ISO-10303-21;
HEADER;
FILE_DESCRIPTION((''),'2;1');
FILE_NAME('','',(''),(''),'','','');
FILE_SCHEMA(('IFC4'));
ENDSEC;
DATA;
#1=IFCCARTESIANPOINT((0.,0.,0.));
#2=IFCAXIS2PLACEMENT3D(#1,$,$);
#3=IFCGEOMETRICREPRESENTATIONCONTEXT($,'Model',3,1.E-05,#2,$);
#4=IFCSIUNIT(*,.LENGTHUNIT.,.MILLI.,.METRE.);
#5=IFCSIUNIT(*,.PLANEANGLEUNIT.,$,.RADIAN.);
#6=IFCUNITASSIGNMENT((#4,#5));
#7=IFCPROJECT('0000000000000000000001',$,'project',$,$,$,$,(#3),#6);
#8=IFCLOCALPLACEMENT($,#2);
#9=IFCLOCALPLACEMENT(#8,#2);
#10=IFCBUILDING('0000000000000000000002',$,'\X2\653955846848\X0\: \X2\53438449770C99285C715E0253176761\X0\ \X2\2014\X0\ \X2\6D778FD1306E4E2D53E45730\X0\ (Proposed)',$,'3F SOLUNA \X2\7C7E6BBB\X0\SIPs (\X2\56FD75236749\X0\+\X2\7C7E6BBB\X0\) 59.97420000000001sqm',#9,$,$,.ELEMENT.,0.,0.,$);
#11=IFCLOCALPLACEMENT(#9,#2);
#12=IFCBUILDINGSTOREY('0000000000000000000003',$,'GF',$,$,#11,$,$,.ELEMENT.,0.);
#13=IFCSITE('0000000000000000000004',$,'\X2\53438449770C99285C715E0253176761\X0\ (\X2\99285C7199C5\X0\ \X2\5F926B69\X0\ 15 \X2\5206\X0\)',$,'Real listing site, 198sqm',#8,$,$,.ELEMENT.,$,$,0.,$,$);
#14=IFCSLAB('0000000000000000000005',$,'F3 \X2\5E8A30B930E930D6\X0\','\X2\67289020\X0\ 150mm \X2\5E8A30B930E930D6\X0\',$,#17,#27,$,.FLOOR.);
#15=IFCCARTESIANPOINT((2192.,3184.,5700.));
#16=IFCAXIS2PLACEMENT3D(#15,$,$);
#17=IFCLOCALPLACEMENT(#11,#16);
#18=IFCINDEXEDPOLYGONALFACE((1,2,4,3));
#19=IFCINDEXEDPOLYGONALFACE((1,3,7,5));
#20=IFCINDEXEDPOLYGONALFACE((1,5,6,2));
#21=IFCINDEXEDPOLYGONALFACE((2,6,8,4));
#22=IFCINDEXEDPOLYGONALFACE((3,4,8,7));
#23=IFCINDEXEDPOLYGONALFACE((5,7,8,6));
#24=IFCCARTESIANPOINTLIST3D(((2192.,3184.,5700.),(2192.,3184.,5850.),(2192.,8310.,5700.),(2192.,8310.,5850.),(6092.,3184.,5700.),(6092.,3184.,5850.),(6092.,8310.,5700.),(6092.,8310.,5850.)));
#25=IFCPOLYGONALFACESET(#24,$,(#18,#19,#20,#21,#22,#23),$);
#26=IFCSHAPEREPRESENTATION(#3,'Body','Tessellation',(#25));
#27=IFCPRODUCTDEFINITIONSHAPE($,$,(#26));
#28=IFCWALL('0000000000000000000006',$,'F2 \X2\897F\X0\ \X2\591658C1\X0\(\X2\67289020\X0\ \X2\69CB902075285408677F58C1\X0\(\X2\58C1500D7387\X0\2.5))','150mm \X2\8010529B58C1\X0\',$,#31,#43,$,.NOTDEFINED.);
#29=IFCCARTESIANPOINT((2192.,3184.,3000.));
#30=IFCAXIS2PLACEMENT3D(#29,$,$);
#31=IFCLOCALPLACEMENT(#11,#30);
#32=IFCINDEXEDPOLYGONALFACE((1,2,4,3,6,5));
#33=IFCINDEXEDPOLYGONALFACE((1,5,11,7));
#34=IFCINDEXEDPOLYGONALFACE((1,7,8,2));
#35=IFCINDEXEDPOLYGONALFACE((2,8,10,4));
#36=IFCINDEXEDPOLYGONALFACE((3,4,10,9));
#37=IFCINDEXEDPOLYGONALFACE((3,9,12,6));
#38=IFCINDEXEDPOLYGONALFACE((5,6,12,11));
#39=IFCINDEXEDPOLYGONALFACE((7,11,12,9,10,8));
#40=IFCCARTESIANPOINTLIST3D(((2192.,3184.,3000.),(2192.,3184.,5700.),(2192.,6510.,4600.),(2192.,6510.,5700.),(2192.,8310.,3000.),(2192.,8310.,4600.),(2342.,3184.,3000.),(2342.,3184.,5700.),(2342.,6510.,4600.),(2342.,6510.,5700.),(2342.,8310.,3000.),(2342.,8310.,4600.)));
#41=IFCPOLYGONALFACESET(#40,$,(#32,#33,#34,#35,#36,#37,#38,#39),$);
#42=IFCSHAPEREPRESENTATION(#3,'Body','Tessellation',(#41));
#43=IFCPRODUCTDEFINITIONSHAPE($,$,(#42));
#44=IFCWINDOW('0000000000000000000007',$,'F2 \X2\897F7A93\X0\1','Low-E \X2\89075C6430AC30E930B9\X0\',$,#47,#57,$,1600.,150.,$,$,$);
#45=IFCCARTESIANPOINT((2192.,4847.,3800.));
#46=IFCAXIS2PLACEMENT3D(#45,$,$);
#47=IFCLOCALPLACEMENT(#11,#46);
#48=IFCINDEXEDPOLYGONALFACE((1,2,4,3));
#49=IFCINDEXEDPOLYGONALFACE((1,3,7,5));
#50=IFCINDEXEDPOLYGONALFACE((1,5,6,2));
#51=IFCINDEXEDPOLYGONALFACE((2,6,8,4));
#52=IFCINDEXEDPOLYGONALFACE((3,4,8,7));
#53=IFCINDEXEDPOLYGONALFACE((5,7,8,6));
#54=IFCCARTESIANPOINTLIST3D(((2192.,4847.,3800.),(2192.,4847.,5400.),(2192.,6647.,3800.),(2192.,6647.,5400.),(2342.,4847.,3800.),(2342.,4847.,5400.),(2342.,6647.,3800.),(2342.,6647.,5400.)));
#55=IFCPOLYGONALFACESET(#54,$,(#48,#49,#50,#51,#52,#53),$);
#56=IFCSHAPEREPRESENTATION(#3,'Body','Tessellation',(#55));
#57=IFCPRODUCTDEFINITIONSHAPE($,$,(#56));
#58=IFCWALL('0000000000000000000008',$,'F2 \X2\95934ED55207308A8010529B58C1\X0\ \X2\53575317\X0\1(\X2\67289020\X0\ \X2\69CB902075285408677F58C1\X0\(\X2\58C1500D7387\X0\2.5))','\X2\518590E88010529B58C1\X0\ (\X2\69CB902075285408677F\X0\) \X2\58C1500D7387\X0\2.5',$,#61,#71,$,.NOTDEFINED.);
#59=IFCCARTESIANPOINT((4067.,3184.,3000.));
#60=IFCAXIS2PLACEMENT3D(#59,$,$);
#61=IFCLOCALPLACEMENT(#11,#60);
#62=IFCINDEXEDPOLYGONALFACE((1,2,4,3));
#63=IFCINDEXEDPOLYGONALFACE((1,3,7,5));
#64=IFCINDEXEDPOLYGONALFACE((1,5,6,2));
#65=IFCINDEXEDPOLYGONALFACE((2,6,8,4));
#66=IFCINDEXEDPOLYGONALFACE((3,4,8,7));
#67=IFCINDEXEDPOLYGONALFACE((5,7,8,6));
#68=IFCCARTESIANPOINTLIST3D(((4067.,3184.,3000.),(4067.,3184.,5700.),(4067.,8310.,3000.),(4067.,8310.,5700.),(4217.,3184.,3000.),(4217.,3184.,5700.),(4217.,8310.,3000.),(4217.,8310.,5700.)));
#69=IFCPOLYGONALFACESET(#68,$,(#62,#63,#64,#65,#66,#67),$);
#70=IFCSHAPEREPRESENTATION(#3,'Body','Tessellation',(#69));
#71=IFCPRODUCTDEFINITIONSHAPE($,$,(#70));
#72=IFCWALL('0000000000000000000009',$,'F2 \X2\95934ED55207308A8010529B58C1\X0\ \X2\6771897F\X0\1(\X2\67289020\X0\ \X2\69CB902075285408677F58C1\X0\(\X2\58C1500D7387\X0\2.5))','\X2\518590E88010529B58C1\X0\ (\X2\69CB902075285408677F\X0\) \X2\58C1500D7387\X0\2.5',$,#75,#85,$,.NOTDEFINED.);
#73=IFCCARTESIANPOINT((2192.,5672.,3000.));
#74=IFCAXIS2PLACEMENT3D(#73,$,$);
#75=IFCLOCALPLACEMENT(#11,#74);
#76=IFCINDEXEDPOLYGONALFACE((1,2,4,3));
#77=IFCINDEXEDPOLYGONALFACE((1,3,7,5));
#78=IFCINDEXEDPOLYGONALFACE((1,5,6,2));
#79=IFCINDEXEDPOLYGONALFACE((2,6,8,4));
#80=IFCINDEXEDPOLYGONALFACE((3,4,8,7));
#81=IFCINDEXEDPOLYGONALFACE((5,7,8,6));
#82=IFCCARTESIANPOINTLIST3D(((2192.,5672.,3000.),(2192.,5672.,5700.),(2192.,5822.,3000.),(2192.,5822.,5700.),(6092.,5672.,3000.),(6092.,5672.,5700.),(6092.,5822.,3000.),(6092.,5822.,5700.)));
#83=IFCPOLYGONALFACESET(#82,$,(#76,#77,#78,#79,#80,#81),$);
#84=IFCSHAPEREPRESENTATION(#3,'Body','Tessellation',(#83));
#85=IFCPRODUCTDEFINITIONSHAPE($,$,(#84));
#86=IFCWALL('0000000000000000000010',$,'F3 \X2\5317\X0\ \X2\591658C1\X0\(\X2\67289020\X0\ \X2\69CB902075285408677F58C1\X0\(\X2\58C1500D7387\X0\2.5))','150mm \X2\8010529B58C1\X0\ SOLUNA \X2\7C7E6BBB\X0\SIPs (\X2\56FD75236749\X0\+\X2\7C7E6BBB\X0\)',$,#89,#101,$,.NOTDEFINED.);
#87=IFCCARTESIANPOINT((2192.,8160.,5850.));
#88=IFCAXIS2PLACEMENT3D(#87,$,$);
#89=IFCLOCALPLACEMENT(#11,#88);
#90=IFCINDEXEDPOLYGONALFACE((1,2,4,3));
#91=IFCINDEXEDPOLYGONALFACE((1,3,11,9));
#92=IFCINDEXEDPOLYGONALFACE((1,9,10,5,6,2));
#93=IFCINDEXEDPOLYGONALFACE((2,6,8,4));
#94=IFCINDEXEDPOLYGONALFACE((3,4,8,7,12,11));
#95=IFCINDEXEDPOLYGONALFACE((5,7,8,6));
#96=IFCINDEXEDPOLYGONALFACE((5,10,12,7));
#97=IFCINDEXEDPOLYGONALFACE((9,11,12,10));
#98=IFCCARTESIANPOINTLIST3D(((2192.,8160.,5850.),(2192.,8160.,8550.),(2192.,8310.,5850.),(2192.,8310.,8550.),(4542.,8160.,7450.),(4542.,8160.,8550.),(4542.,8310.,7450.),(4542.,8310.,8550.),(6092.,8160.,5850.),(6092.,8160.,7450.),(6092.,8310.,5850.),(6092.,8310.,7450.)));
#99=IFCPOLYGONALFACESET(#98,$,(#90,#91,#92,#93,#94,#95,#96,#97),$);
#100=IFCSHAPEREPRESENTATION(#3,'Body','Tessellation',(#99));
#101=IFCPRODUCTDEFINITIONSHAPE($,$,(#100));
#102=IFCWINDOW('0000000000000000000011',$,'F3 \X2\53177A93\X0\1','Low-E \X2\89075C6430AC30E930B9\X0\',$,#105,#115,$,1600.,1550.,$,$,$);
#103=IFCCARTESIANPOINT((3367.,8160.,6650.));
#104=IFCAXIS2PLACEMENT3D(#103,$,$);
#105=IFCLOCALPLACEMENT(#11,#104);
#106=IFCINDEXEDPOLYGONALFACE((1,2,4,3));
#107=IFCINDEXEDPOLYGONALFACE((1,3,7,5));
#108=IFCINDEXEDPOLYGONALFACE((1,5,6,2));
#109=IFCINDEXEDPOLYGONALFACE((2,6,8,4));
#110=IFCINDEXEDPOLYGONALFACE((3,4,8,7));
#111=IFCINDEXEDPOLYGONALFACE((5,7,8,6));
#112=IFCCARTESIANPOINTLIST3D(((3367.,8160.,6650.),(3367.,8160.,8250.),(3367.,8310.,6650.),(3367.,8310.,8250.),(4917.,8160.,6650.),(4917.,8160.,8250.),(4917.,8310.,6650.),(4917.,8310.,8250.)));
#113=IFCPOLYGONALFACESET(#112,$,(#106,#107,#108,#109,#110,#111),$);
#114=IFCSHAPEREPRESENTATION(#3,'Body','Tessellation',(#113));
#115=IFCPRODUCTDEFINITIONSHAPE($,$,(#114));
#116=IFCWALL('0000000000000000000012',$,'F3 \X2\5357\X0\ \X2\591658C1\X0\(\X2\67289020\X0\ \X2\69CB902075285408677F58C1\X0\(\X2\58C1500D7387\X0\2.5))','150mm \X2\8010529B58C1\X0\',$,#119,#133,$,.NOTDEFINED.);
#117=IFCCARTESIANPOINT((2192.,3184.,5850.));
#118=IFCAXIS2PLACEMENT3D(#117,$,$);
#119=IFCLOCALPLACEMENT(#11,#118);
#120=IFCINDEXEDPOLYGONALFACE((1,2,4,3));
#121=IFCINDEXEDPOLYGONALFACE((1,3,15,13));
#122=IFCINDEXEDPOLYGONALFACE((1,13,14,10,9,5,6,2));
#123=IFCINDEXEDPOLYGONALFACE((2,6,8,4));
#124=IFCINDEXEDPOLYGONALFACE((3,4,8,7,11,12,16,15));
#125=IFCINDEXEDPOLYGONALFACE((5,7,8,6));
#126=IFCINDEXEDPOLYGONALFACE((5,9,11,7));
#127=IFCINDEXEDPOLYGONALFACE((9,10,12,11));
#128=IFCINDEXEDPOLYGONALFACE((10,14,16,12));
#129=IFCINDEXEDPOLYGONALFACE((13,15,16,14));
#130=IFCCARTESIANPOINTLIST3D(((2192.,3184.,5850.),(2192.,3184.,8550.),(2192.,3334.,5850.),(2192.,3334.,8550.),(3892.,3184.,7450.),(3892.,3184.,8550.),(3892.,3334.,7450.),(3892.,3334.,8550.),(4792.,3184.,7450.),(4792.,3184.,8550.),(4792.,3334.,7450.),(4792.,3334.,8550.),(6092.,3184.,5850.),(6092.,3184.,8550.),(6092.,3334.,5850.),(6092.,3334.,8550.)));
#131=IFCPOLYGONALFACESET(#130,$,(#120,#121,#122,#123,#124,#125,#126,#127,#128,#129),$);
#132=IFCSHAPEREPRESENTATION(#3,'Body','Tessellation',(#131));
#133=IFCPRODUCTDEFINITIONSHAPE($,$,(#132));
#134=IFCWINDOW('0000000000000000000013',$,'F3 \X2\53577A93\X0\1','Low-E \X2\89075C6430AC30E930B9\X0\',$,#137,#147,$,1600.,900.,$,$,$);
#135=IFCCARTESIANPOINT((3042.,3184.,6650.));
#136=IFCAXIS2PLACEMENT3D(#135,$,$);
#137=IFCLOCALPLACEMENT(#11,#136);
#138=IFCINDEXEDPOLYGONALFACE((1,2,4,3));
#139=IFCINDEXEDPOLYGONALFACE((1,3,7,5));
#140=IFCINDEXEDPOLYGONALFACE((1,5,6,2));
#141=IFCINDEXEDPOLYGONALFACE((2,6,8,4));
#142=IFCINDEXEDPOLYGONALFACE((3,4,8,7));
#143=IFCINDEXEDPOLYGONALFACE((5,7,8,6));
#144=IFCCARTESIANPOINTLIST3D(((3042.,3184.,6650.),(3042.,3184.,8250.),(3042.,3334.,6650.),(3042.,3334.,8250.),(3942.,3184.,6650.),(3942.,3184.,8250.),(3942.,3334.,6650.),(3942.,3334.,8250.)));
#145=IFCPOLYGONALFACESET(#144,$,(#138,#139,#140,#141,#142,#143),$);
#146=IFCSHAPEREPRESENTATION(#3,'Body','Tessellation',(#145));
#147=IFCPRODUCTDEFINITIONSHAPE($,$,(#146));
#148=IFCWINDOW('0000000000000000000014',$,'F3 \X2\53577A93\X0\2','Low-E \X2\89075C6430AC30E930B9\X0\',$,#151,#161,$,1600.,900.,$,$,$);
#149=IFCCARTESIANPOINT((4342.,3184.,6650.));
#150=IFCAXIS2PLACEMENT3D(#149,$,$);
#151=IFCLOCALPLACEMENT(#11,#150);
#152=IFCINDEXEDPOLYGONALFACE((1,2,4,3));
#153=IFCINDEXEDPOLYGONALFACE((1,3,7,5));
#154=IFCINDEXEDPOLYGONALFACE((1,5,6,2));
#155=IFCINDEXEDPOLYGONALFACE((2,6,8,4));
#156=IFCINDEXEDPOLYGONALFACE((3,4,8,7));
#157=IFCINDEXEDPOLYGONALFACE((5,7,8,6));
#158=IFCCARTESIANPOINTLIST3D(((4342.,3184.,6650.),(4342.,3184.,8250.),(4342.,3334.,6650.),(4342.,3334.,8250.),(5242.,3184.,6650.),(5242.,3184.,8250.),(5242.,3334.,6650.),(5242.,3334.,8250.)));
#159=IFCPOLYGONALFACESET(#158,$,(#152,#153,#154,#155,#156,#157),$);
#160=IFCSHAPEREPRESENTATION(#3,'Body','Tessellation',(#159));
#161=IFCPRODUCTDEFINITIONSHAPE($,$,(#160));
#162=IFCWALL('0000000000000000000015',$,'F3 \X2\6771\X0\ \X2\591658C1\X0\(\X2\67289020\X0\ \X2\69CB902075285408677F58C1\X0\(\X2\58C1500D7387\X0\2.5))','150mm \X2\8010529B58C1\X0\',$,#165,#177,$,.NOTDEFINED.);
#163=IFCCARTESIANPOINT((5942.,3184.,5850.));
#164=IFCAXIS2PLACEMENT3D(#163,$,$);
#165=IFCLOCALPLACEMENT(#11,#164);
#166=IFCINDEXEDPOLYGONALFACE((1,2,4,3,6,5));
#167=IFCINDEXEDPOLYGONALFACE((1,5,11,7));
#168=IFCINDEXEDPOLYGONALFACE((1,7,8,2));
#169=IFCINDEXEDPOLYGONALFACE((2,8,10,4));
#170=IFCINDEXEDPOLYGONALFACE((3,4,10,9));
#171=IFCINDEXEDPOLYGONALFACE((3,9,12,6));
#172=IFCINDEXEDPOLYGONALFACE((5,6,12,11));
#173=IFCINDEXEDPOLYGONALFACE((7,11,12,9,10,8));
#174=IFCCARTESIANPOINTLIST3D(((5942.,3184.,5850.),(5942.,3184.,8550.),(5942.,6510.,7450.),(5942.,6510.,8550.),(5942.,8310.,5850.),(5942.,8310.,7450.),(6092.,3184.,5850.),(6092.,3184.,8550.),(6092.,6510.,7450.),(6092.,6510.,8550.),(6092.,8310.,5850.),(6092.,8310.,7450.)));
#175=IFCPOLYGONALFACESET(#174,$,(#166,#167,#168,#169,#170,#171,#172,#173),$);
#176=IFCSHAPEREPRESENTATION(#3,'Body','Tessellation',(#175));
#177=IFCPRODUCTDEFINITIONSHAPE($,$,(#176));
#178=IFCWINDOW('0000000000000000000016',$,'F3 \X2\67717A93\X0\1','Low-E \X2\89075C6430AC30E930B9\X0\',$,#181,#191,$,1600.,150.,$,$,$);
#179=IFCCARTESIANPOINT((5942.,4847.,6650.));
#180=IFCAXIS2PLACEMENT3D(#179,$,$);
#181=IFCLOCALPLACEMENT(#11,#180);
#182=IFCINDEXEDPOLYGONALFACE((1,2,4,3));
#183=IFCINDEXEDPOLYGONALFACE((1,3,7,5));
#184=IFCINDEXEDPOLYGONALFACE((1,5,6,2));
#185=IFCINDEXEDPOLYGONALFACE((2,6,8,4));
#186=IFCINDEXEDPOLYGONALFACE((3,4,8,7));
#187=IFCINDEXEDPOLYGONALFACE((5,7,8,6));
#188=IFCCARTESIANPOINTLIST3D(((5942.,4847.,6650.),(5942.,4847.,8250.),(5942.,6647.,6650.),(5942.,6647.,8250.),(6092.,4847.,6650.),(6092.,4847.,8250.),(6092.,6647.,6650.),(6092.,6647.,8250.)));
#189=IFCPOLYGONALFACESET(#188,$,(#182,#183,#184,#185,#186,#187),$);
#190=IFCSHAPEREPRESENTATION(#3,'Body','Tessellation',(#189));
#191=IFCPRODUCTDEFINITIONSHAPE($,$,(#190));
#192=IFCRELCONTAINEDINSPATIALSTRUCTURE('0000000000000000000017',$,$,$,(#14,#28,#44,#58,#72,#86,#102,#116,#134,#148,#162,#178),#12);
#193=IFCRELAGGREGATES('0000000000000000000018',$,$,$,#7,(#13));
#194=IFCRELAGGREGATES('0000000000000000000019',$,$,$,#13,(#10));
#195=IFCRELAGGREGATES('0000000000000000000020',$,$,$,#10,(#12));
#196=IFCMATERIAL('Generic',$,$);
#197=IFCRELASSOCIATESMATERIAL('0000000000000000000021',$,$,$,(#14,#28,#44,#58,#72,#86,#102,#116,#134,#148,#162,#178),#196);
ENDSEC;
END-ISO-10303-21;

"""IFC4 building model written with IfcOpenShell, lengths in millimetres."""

from ifc_helpers import new_model, si_unit, frame, frame_2d, origin, place, context, project, spatial, rectangle, extrude, material, element, fill, save


model = new_model("IFC4")

# Units and contexts
model_context = context("Model", 3, precision=1e-05, world=origin())
ifc_project = project(units=[si_unit("LENGTHUNIT", "METRE", prefix="MILLI"), si_unit("PLANEANGLEUNIT", "RADIAN")], contexts=[model_context])

# Site, building, storey
site_placement = place(None, origin())
site = spatial("IfcSite", under=ifc_project, at=site_placement, Name="千葉県館山市北条 (館山駅 徒歩 15 分)", ObjectType="Real listing site, 198sqm", CompositionType="ELEMENT", RefElevation=0.0)
building_placement = place(site_placement, origin())
building = spatial("IfcBuilding", under=site, at=building_placement, Name="改善案: 千葉県館山市北条 — 海近の中古地 (Proposed)", ObjectType="3F SOLUNA 籾殻SIPs (国産杉+籾殻) 59.97420000000001sqm", CompositionType="ELEMENT", ElevationOfRefHeight=0.0, ElevationOfTerrain=0.0)
storey_placement = place(building_placement, origin())
storey = spatial("IfcBuildingStorey", under=building, at=storey_placement, Name="GF", CompositionType="ELEMENT", Elevation=0.0)

# Slab
ifc_material_1 = material(Name="Generic")
slab_placement = place(storey_placement, frame((2192.0, 3184.0, 5700.0)))
element("IfcSlab", 1, at=slab_placement, inside=storey, material=ifc_material_1, Name="F3 床スラブ", Description="木造 150mm 床スラブ", PredefinedType="FLOOR", context=model_context, shape_type="SweptSolid", body=[
    extrude(rectangle(XDim=3900.0, YDim=5126.0, at=frame_2d((1950.0, 2563.0))), frame((2192.0, 3184.0, 5700.0)), (0.0, 0.0, 1.0), 150.0),
])

# Wall, opening, window
wall_1_placement = place(storey_placement, frame((2192.0, 3184.0, 3000.0)))
wall_1 = element("IfcWall", 2, at=wall_1_placement, inside=storey, material=ifc_material_1, Name="F2 西 外壁(木造 構造用合板壁(壁倍率2.5))", Description="150mm 耐力壁", PredefinedType="NOTDEFINED", context=model_context, shape_type="SweptSolid", body=[
    extrude(rectangle(XDim=150.0, YDim=5126.0, at=frame_2d((75.0, 2563.0))), frame((2192.0, 3184.0, 3000.0)), (0.0, 0.0, 1.0), 2700.0),
])
opening_1_placement = place(storey_placement, frame((2192.0, 4847.0, 3800.0)))
opening_1 = element("IfcOpeningElement", 3, at=opening_1_placement, cuts=wall_1, PredefinedType="NOTDEFINED", context=model_context, shape_type="SweptSolid", body=[
    extrude(rectangle(XDim=150.0, YDim=1800.0, at=frame_2d((75.0, 900.0))), frame((2192.0, 4847.0, 3800.0)), (0.0, 0.0, 1.0), 1600.0),
])
window_1_placement = place(storey_placement, frame((2192.0, 4847.0, 3800.0)))
window_1 = element("IfcWindow", 4, at=window_1_placement, inside=storey, material=ifc_material_1, Name="F2 西窓1", Description="Low-E 複層ガラス", OverallHeight=1600.0, OverallWidth=150.0, context=model_context, shape_type="SweptSolid", body=[
    extrude(rectangle(XDim=150.0, YDim=1800.0, at=frame_2d((75.0, 900.0))), frame((2192.0, 4847.0, 3800.0)), (0.0, 0.0, 1.0), 1600.0),
])
fill(opening_1, window_1)

# Walls
wall_2_placement = place(storey_placement, frame((4067.0, 3184.0, 3000.0)))
element("IfcWall", 5, at=wall_2_placement, inside=storey, material=ifc_material_1, Name="F2 間仕切り耐力壁 南北1(木造 構造用合板壁(壁倍率2.5))", Description="内部耐力壁 (構造用合板) 壁倍率2.5", PredefinedType="NOTDEFINED", context=model_context, shape_type="SweptSolid", body=[
    extrude(rectangle(XDim=150.0, YDim=5126.0, at=frame_2d((75.0, 2563.0))), frame((4067.0, 3184.0, 3000.0)), (0.0, 0.0, 1.0), 2700.0),
])
wall_3_placement = place(storey_placement, frame((2192.0, 5672.0, 3000.0)))
element("IfcWall", 6, at=wall_3_placement, inside=storey, material=ifc_material_1, Name="F2 間仕切り耐力壁 東西1(木造 構造用合板壁(壁倍率2.5))", Description="内部耐力壁 (構造用合板) 壁倍率2.5", PredefinedType="NOTDEFINED", context=model_context, shape_type="SweptSolid", body=[
    extrude(rectangle(XDim=3900.0, YDim=150.0, at=frame_2d((1950.0, 75.0))), frame((2192.0, 5672.0, 3000.0)), (0.0, 0.0, 1.0), 2700.0),
])

# Wall, opening, window
wall_4_placement = place(storey_placement, frame((2192.0, 8160.0, 5850.0)))
wall_4 = element("IfcWall", 7, at=wall_4_placement, inside=storey, material=ifc_material_1, Name="F3 北 外壁(木造 構造用合板壁(壁倍率2.5))", Description="150mm 耐力壁 SOLUNA 籾殻SIPs (国産杉+籾殻)", PredefinedType="NOTDEFINED", context=model_context, shape_type="SweptSolid", body=[
    extrude(rectangle(XDim=3900.0, YDim=150.0, at=frame_2d((1950.0, 75.0))), frame((2192.0, 8160.0, 5850.0)), (0.0, 0.0, 1.0), 2700.0),
])
opening_2_placement = place(storey_placement, frame((3367.0, 8160.0, 6650.0)))
opening_2 = element("IfcOpeningElement", 8, at=opening_2_placement, cuts=wall_4, PredefinedType="NOTDEFINED", context=model_context, shape_type="SweptSolid", body=[
    extrude(rectangle(XDim=1550.0, YDim=150.0, at=frame_2d((775.0, 75.0))), frame((3367.0, 8160.0, 6650.0)), (0.0, 0.0, 1.0), 1600.0),
])
window_2_placement = place(storey_placement, frame((3367.0, 8160.0, 6650.0)))
window_2 = element("IfcWindow", 9, at=window_2_placement, inside=storey, material=ifc_material_1, Name="F3 北窓1", Description="Low-E 複層ガラス", OverallHeight=1600.0, OverallWidth=1550.0, context=model_context, shape_type="SweptSolid", body=[
    extrude(rectangle(XDim=1550.0, YDim=150.0, at=frame_2d((775.0, 75.0))), frame((3367.0, 8160.0, 6650.0)), (0.0, 0.0, 1.0), 1600.0),
])
fill(opening_2, window_2)

# Wall, openings, windows
wall_5_placement = place(storey_placement, frame((2192.0, 3184.0, 5850.0)))
wall_5 = element("IfcWall", 10, at=wall_5_placement, inside=storey, material=ifc_material_1, Name="F3 南 外壁(木造 構造用合板壁(壁倍率2.5))", Description="150mm 耐力壁", PredefinedType="NOTDEFINED", context=model_context, shape_type="SweptSolid", body=[
    extrude(rectangle(XDim=3900.0, YDim=150.0, at=frame_2d((1950.0, 75.0))), frame((2192.0, 3184.0, 5850.0)), (0.0, 0.0, 1.0), 2700.0),
])
opening_3_placement = place(storey_placement, frame((3042.0, 3184.0, 6650.0)))
opening_3 = element("IfcOpeningElement", 11, at=opening_3_placement, cuts=wall_5, PredefinedType="NOTDEFINED", context=model_context, shape_type="SweptSolid", body=[
    extrude(rectangle(XDim=900.0, YDim=150.0, at=frame_2d((450.0, 75.0))), frame((3042.0, 3184.0, 6650.0)), (0.0, 0.0, 1.0), 1600.0),
])
opening_4_placement = place(storey_placement, frame((4342.0, 3184.0, 6650.0)))
opening_4 = element("IfcOpeningElement", 12, at=opening_4_placement, cuts=wall_5, PredefinedType="NOTDEFINED", context=model_context, shape_type="SweptSolid", body=[
    extrude(rectangle(XDim=900.0, YDim=150.0, at=frame_2d((450.0, 75.0))), frame((4342.0, 3184.0, 6650.0)), (0.0, 0.0, 1.0), 1600.0),
])
window_3_placement = place(storey_placement, frame((3042.0, 3184.0, 6650.0)))
window_3 = element("IfcWindow", 13, at=window_3_placement, inside=storey, material=ifc_material_1, Name="F3 南窓1", Description="Low-E 複層ガラス", OverallHeight=1600.0, OverallWidth=900.0, context=model_context, shape_type="SweptSolid", body=[
    extrude(rectangle(XDim=900.0, YDim=150.0, at=frame_2d((450.0, 75.0))), frame((3042.0, 3184.0, 6650.0)), (0.0, 0.0, 1.0), 1600.0),
])
fill(opening_3, window_3)
window_4_placement = place(storey_placement, frame((4342.0, 3184.0, 6650.0)))
window_4 = element("IfcWindow", 14, at=window_4_placement, inside=storey, material=ifc_material_1, Name="F3 南窓2", Description="Low-E 複層ガラス", OverallHeight=1600.0, OverallWidth=900.0, context=model_context, shape_type="SweptSolid", body=[
    extrude(rectangle(XDim=900.0, YDim=150.0, at=frame_2d((450.0, 75.0))), frame((4342.0, 3184.0, 6650.0)), (0.0, 0.0, 1.0), 1600.0),
])
fill(opening_4, window_4)

# Wall, opening, window
wall_6_placement = place(storey_placement, frame((5942.0, 3184.0, 5850.0)))
wall_6 = element("IfcWall", 15, at=wall_6_placement, inside=storey, material=ifc_material_1, Name="F3 東 外壁(木造 構造用合板壁(壁倍率2.5))", Description="150mm 耐力壁", PredefinedType="NOTDEFINED", context=model_context, shape_type="SweptSolid", body=[
    extrude(rectangle(XDim=150.0, YDim=5126.0, at=frame_2d((75.0, 2563.0))), frame((5942.0, 3184.0, 5850.0)), (0.0, 0.0, 1.0), 2700.0),
])
opening_5_placement = place(storey_placement, frame((5942.0, 4847.0, 6650.0)))
opening_5 = element("IfcOpeningElement", 16, at=opening_5_placement, cuts=wall_6, PredefinedType="NOTDEFINED", context=model_context, shape_type="SweptSolid", body=[
    extrude(rectangle(XDim=150.0, YDim=1800.0, at=frame_2d((75.0, 900.0))), frame((5942.0, 4847.0, 6650.0)), (0.0, 0.0, 1.0), 1600.0),
])
window_5_placement = place(storey_placement, frame((5942.0, 4847.0, 6650.0)))
window_5 = element("IfcWindow", 17, at=window_5_placement, inside=storey, material=ifc_material_1, Name="F3 東窓1", Description="Low-E 複層ガラス", OverallHeight=1600.0, OverallWidth=150.0, context=model_context, shape_type="SweptSolid", body=[
    extrude(rectangle(XDim=150.0, YDim=1800.0, at=frame_2d((75.0, 900.0))), frame((5942.0, 4847.0, 6650.0)), (0.0, 0.0, 1.0), 1600.0),
])
fill(opening_5, window_5)

save(model, "model.ifc")
